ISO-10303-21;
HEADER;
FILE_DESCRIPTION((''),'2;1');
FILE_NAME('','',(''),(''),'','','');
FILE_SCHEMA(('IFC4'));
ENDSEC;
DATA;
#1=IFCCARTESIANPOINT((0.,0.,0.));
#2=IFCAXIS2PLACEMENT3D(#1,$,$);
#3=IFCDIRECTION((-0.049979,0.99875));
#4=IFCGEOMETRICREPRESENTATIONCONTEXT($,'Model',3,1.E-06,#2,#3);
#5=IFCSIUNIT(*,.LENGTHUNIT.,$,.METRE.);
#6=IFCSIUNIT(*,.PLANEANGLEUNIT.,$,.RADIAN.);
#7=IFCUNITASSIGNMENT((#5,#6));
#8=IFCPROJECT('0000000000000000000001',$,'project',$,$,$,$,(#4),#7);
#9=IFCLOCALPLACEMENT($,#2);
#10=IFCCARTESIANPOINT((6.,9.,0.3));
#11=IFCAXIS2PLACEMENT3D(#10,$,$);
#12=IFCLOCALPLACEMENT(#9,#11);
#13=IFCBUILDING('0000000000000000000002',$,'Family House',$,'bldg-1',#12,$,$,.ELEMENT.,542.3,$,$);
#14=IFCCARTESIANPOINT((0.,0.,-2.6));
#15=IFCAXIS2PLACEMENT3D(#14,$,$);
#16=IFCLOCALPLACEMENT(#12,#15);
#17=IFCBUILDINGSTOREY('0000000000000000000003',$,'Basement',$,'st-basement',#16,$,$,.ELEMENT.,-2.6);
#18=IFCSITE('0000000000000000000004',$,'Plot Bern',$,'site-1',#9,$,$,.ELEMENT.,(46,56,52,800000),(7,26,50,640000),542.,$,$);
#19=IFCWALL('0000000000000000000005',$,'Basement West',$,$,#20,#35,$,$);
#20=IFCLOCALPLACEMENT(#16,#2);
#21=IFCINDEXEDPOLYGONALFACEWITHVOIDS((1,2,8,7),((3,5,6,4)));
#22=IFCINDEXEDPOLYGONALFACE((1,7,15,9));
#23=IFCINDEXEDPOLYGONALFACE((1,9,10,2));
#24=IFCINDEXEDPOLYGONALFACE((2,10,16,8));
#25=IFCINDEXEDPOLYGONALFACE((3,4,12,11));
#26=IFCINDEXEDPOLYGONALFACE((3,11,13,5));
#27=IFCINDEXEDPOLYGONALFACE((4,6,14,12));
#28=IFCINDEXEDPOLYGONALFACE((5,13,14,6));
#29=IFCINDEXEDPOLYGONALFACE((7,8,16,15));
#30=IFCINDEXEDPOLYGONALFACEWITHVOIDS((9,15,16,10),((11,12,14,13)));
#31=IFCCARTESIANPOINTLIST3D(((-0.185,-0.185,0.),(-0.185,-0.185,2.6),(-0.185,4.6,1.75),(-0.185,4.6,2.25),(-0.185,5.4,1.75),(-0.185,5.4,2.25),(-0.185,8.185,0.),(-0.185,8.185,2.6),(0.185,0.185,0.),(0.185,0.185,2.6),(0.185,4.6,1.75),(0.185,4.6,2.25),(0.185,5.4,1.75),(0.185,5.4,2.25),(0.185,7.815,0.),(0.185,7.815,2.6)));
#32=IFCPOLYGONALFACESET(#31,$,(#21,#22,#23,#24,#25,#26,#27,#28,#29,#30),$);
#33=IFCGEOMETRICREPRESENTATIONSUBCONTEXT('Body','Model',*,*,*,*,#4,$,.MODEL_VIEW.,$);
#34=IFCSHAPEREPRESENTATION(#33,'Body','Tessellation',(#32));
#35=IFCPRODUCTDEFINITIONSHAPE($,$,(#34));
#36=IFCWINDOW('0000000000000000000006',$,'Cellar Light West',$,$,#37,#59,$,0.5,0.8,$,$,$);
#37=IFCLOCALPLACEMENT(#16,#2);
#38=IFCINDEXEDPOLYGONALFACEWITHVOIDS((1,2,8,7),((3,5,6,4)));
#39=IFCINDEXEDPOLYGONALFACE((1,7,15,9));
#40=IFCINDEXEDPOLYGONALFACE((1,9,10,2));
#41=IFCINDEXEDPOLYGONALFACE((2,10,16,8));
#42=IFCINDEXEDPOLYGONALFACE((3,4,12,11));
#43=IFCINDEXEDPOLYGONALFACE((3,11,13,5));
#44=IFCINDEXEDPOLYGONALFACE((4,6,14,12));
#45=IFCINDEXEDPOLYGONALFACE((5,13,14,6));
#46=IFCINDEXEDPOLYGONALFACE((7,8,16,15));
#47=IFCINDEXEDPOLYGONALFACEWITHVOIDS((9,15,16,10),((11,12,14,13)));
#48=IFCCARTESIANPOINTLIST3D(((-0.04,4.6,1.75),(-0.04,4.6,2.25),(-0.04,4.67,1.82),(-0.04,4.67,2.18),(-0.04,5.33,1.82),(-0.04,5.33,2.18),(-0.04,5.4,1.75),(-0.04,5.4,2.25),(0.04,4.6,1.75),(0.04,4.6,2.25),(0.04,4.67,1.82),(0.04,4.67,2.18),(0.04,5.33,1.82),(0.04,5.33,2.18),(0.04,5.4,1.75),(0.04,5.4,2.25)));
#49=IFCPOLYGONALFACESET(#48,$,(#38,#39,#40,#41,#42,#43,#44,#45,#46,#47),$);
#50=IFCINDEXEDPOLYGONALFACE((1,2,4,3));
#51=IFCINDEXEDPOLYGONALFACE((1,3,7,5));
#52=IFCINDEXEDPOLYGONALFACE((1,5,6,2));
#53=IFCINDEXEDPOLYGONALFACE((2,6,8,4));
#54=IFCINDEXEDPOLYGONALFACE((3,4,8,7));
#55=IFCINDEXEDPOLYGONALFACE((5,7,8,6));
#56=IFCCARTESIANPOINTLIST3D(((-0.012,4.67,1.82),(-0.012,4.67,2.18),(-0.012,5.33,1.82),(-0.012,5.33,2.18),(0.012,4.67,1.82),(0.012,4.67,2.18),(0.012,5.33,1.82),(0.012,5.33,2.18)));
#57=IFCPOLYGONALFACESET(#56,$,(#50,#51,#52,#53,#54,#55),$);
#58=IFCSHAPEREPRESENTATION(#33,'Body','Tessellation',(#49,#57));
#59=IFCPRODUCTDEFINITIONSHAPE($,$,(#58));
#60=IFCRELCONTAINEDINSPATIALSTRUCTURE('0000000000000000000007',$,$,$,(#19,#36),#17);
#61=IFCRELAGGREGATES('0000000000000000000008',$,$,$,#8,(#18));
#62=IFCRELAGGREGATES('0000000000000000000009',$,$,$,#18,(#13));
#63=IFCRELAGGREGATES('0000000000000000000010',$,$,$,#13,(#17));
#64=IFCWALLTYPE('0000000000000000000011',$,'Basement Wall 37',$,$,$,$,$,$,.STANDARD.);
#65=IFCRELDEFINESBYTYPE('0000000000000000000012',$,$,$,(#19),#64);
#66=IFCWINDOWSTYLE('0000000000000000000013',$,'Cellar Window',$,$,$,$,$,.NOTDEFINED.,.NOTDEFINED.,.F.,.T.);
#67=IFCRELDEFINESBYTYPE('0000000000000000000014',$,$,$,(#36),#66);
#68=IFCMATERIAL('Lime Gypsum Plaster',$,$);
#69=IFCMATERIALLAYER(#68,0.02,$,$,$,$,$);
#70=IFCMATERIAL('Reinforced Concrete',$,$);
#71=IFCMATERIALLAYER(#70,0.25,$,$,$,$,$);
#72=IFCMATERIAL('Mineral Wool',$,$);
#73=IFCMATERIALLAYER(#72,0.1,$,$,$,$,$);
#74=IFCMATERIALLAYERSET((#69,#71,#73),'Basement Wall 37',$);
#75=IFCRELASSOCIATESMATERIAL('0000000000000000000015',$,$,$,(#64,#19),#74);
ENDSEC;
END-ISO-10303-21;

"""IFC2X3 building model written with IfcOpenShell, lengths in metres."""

from ifc_helpers import new_model, si_unit, direction, frame, frame_2d, origin, origin_2d, place, context, subcontext, project, spatial, polyline, rectangle, outline, extrude, material, layer, layer_set, layer_usage, type_object, element, fill, save


model = new_model("IFC2X3")

# Units and contexts
model_context = context("Model", 3, precision=1e-06, world=origin(), true_north=direction((-0.049979, 0.99875)))
body_context = subcontext(model_context, "Body", "Model", "MODEL_VIEW")
ifc_project = project(units=[si_unit("LENGTHUNIT", "METRE"), si_unit("PLANEANGLEUNIT", "RADIAN")], contexts=[model_context])

# Site, building, storey
site_placement = place(None, origin())
site = spatial("IfcSite", under=ifc_project, at=site_placement, Name="Plot Bern", ObjectType="site-1", CompositionType="ELEMENT", RefLatitude=(46, 56, 52, 800000), RefLongitude=(7, 26, 50, 640000), RefElevation=542.0)
building_placement = place(site_placement, frame((6.0, 9.0, 0.3)))
building = spatial("IfcBuilding", under=site, at=building_placement, Name="Family House", ObjectType="bldg-1", CompositionType="ELEMENT", ElevationOfRefHeight=542.3)
storey_placement = place(building_placement, frame((0.0, 0.0, -2.6)))
storey = spatial("IfcBuildingStorey", under=building, at=storey_placement, Name="Basement", ObjectType="st-basement", CompositionType="ELEMENT", Elevation=-2.6)

# Shared definitions
ifc_material_1 = material(Name="Mineral Wool")
ifc_material_2 = material(Name="Reinforced Concrete")

# Shared definitions
ifc_material_3 = material(Name="Lime Gypsum Plaster")
ifc_layer_1 = layer(ifc_material_3, 0.02)
ifc_layer_2 = layer(ifc_material_2, 0.25)
ifc_layer_3 = layer(ifc_material_1, 0.1)
ifc_layer_set_1 = layer_set([ifc_layer_1, ifc_layer_2, ifc_layer_3], Name="Basement Wall 37")
wall_type_1 = type_object("IfcWallType", Name="Basement Wall 37", PredefinedType="STANDARD", material=ifc_layer_set_1)

# Shared definitions
window_style = type_object("IfcWindowStyle", Name="Cellar Window", ConstructionType="NOTDEFINED", OperationType="NOTDEFINED", ParameterTakesPrecedence=False, Sizeable=True)

# Wall, opening, window
ifc_layer_usage_1 = layer_usage(ifc_layer_set_1, "AXIS2", "NEGATIVE", 0.185)
wall_1_placement = place(storey_placement, origin())
wall_1 = element("IfcWall", 1, at=wall_1_placement, inside=storey, type_object=wall_type_1, material=ifc_layer_usage_1, Name="Basement West", context=body_context, shape_type="SweptSolid", body=[
    extrude(outline(polyline([(-0.185, 8.185), (-0.185, -0.185), (0.185, 0.185), (0.185, 7.815), (-0.185, 8.185)])), origin(), (0.0, 0.0, 1.0), 2.6),
])
opening_1_placement = place(wall_1_placement, frame((0.0, 5.0, 1.75), z_axis=(0.0, 0.0, 1.0), x_axis=(0.0, -1.0, 0.0)))
opening_1 = element("IfcOpeningElement", 2, at=opening_1_placement, cuts=wall_1, context=body_context, shape_type="SweptSolid", body=[
    extrude(rectangle(XDim=0.8, YDim=0.37, at=origin_2d()), origin(), (0.0, 0.0, 1.0), 0.5),
])
window_1_placement = place(opening_1_placement, frame((0.0, 0.0, 0.0), z_axis=(0.0, -1.0, 0.0), x_axis=(1.0, 0.0, 0.0)))
window_1 = element("IfcWindow", 3, at=window_1_placement, inside=storey, type_object=window_style, Name="Cellar Light West", OverallHeight=0.5, OverallWidth=0.8, context=body_context, shape_type="SweptSolid", body=[
    extrude(outline(polyline([(-0.4, 0.0), (0.4, 0.0), (0.4, 0.5), (-0.4, 0.5), (-0.4, 0.0)]), holes=[polyline([(-0.33, 0.07), (0.33, 0.07), (0.33, 0.43), (-0.33, 0.43), (-0.33, 0.07)])]), frame((0.0, 0.0, -0.04)), (0.0, 0.0, 1.0), 0.08),
    extrude(rectangle(XDim=0.66, YDim=0.36, at=frame_2d((0.0, 0.25))), frame((0.0, 0.0, -0.012)), (0.0, 0.0, 1.0), 0.024),
])
fill(opening_1, window_1)

save(model, "model.ifc")
